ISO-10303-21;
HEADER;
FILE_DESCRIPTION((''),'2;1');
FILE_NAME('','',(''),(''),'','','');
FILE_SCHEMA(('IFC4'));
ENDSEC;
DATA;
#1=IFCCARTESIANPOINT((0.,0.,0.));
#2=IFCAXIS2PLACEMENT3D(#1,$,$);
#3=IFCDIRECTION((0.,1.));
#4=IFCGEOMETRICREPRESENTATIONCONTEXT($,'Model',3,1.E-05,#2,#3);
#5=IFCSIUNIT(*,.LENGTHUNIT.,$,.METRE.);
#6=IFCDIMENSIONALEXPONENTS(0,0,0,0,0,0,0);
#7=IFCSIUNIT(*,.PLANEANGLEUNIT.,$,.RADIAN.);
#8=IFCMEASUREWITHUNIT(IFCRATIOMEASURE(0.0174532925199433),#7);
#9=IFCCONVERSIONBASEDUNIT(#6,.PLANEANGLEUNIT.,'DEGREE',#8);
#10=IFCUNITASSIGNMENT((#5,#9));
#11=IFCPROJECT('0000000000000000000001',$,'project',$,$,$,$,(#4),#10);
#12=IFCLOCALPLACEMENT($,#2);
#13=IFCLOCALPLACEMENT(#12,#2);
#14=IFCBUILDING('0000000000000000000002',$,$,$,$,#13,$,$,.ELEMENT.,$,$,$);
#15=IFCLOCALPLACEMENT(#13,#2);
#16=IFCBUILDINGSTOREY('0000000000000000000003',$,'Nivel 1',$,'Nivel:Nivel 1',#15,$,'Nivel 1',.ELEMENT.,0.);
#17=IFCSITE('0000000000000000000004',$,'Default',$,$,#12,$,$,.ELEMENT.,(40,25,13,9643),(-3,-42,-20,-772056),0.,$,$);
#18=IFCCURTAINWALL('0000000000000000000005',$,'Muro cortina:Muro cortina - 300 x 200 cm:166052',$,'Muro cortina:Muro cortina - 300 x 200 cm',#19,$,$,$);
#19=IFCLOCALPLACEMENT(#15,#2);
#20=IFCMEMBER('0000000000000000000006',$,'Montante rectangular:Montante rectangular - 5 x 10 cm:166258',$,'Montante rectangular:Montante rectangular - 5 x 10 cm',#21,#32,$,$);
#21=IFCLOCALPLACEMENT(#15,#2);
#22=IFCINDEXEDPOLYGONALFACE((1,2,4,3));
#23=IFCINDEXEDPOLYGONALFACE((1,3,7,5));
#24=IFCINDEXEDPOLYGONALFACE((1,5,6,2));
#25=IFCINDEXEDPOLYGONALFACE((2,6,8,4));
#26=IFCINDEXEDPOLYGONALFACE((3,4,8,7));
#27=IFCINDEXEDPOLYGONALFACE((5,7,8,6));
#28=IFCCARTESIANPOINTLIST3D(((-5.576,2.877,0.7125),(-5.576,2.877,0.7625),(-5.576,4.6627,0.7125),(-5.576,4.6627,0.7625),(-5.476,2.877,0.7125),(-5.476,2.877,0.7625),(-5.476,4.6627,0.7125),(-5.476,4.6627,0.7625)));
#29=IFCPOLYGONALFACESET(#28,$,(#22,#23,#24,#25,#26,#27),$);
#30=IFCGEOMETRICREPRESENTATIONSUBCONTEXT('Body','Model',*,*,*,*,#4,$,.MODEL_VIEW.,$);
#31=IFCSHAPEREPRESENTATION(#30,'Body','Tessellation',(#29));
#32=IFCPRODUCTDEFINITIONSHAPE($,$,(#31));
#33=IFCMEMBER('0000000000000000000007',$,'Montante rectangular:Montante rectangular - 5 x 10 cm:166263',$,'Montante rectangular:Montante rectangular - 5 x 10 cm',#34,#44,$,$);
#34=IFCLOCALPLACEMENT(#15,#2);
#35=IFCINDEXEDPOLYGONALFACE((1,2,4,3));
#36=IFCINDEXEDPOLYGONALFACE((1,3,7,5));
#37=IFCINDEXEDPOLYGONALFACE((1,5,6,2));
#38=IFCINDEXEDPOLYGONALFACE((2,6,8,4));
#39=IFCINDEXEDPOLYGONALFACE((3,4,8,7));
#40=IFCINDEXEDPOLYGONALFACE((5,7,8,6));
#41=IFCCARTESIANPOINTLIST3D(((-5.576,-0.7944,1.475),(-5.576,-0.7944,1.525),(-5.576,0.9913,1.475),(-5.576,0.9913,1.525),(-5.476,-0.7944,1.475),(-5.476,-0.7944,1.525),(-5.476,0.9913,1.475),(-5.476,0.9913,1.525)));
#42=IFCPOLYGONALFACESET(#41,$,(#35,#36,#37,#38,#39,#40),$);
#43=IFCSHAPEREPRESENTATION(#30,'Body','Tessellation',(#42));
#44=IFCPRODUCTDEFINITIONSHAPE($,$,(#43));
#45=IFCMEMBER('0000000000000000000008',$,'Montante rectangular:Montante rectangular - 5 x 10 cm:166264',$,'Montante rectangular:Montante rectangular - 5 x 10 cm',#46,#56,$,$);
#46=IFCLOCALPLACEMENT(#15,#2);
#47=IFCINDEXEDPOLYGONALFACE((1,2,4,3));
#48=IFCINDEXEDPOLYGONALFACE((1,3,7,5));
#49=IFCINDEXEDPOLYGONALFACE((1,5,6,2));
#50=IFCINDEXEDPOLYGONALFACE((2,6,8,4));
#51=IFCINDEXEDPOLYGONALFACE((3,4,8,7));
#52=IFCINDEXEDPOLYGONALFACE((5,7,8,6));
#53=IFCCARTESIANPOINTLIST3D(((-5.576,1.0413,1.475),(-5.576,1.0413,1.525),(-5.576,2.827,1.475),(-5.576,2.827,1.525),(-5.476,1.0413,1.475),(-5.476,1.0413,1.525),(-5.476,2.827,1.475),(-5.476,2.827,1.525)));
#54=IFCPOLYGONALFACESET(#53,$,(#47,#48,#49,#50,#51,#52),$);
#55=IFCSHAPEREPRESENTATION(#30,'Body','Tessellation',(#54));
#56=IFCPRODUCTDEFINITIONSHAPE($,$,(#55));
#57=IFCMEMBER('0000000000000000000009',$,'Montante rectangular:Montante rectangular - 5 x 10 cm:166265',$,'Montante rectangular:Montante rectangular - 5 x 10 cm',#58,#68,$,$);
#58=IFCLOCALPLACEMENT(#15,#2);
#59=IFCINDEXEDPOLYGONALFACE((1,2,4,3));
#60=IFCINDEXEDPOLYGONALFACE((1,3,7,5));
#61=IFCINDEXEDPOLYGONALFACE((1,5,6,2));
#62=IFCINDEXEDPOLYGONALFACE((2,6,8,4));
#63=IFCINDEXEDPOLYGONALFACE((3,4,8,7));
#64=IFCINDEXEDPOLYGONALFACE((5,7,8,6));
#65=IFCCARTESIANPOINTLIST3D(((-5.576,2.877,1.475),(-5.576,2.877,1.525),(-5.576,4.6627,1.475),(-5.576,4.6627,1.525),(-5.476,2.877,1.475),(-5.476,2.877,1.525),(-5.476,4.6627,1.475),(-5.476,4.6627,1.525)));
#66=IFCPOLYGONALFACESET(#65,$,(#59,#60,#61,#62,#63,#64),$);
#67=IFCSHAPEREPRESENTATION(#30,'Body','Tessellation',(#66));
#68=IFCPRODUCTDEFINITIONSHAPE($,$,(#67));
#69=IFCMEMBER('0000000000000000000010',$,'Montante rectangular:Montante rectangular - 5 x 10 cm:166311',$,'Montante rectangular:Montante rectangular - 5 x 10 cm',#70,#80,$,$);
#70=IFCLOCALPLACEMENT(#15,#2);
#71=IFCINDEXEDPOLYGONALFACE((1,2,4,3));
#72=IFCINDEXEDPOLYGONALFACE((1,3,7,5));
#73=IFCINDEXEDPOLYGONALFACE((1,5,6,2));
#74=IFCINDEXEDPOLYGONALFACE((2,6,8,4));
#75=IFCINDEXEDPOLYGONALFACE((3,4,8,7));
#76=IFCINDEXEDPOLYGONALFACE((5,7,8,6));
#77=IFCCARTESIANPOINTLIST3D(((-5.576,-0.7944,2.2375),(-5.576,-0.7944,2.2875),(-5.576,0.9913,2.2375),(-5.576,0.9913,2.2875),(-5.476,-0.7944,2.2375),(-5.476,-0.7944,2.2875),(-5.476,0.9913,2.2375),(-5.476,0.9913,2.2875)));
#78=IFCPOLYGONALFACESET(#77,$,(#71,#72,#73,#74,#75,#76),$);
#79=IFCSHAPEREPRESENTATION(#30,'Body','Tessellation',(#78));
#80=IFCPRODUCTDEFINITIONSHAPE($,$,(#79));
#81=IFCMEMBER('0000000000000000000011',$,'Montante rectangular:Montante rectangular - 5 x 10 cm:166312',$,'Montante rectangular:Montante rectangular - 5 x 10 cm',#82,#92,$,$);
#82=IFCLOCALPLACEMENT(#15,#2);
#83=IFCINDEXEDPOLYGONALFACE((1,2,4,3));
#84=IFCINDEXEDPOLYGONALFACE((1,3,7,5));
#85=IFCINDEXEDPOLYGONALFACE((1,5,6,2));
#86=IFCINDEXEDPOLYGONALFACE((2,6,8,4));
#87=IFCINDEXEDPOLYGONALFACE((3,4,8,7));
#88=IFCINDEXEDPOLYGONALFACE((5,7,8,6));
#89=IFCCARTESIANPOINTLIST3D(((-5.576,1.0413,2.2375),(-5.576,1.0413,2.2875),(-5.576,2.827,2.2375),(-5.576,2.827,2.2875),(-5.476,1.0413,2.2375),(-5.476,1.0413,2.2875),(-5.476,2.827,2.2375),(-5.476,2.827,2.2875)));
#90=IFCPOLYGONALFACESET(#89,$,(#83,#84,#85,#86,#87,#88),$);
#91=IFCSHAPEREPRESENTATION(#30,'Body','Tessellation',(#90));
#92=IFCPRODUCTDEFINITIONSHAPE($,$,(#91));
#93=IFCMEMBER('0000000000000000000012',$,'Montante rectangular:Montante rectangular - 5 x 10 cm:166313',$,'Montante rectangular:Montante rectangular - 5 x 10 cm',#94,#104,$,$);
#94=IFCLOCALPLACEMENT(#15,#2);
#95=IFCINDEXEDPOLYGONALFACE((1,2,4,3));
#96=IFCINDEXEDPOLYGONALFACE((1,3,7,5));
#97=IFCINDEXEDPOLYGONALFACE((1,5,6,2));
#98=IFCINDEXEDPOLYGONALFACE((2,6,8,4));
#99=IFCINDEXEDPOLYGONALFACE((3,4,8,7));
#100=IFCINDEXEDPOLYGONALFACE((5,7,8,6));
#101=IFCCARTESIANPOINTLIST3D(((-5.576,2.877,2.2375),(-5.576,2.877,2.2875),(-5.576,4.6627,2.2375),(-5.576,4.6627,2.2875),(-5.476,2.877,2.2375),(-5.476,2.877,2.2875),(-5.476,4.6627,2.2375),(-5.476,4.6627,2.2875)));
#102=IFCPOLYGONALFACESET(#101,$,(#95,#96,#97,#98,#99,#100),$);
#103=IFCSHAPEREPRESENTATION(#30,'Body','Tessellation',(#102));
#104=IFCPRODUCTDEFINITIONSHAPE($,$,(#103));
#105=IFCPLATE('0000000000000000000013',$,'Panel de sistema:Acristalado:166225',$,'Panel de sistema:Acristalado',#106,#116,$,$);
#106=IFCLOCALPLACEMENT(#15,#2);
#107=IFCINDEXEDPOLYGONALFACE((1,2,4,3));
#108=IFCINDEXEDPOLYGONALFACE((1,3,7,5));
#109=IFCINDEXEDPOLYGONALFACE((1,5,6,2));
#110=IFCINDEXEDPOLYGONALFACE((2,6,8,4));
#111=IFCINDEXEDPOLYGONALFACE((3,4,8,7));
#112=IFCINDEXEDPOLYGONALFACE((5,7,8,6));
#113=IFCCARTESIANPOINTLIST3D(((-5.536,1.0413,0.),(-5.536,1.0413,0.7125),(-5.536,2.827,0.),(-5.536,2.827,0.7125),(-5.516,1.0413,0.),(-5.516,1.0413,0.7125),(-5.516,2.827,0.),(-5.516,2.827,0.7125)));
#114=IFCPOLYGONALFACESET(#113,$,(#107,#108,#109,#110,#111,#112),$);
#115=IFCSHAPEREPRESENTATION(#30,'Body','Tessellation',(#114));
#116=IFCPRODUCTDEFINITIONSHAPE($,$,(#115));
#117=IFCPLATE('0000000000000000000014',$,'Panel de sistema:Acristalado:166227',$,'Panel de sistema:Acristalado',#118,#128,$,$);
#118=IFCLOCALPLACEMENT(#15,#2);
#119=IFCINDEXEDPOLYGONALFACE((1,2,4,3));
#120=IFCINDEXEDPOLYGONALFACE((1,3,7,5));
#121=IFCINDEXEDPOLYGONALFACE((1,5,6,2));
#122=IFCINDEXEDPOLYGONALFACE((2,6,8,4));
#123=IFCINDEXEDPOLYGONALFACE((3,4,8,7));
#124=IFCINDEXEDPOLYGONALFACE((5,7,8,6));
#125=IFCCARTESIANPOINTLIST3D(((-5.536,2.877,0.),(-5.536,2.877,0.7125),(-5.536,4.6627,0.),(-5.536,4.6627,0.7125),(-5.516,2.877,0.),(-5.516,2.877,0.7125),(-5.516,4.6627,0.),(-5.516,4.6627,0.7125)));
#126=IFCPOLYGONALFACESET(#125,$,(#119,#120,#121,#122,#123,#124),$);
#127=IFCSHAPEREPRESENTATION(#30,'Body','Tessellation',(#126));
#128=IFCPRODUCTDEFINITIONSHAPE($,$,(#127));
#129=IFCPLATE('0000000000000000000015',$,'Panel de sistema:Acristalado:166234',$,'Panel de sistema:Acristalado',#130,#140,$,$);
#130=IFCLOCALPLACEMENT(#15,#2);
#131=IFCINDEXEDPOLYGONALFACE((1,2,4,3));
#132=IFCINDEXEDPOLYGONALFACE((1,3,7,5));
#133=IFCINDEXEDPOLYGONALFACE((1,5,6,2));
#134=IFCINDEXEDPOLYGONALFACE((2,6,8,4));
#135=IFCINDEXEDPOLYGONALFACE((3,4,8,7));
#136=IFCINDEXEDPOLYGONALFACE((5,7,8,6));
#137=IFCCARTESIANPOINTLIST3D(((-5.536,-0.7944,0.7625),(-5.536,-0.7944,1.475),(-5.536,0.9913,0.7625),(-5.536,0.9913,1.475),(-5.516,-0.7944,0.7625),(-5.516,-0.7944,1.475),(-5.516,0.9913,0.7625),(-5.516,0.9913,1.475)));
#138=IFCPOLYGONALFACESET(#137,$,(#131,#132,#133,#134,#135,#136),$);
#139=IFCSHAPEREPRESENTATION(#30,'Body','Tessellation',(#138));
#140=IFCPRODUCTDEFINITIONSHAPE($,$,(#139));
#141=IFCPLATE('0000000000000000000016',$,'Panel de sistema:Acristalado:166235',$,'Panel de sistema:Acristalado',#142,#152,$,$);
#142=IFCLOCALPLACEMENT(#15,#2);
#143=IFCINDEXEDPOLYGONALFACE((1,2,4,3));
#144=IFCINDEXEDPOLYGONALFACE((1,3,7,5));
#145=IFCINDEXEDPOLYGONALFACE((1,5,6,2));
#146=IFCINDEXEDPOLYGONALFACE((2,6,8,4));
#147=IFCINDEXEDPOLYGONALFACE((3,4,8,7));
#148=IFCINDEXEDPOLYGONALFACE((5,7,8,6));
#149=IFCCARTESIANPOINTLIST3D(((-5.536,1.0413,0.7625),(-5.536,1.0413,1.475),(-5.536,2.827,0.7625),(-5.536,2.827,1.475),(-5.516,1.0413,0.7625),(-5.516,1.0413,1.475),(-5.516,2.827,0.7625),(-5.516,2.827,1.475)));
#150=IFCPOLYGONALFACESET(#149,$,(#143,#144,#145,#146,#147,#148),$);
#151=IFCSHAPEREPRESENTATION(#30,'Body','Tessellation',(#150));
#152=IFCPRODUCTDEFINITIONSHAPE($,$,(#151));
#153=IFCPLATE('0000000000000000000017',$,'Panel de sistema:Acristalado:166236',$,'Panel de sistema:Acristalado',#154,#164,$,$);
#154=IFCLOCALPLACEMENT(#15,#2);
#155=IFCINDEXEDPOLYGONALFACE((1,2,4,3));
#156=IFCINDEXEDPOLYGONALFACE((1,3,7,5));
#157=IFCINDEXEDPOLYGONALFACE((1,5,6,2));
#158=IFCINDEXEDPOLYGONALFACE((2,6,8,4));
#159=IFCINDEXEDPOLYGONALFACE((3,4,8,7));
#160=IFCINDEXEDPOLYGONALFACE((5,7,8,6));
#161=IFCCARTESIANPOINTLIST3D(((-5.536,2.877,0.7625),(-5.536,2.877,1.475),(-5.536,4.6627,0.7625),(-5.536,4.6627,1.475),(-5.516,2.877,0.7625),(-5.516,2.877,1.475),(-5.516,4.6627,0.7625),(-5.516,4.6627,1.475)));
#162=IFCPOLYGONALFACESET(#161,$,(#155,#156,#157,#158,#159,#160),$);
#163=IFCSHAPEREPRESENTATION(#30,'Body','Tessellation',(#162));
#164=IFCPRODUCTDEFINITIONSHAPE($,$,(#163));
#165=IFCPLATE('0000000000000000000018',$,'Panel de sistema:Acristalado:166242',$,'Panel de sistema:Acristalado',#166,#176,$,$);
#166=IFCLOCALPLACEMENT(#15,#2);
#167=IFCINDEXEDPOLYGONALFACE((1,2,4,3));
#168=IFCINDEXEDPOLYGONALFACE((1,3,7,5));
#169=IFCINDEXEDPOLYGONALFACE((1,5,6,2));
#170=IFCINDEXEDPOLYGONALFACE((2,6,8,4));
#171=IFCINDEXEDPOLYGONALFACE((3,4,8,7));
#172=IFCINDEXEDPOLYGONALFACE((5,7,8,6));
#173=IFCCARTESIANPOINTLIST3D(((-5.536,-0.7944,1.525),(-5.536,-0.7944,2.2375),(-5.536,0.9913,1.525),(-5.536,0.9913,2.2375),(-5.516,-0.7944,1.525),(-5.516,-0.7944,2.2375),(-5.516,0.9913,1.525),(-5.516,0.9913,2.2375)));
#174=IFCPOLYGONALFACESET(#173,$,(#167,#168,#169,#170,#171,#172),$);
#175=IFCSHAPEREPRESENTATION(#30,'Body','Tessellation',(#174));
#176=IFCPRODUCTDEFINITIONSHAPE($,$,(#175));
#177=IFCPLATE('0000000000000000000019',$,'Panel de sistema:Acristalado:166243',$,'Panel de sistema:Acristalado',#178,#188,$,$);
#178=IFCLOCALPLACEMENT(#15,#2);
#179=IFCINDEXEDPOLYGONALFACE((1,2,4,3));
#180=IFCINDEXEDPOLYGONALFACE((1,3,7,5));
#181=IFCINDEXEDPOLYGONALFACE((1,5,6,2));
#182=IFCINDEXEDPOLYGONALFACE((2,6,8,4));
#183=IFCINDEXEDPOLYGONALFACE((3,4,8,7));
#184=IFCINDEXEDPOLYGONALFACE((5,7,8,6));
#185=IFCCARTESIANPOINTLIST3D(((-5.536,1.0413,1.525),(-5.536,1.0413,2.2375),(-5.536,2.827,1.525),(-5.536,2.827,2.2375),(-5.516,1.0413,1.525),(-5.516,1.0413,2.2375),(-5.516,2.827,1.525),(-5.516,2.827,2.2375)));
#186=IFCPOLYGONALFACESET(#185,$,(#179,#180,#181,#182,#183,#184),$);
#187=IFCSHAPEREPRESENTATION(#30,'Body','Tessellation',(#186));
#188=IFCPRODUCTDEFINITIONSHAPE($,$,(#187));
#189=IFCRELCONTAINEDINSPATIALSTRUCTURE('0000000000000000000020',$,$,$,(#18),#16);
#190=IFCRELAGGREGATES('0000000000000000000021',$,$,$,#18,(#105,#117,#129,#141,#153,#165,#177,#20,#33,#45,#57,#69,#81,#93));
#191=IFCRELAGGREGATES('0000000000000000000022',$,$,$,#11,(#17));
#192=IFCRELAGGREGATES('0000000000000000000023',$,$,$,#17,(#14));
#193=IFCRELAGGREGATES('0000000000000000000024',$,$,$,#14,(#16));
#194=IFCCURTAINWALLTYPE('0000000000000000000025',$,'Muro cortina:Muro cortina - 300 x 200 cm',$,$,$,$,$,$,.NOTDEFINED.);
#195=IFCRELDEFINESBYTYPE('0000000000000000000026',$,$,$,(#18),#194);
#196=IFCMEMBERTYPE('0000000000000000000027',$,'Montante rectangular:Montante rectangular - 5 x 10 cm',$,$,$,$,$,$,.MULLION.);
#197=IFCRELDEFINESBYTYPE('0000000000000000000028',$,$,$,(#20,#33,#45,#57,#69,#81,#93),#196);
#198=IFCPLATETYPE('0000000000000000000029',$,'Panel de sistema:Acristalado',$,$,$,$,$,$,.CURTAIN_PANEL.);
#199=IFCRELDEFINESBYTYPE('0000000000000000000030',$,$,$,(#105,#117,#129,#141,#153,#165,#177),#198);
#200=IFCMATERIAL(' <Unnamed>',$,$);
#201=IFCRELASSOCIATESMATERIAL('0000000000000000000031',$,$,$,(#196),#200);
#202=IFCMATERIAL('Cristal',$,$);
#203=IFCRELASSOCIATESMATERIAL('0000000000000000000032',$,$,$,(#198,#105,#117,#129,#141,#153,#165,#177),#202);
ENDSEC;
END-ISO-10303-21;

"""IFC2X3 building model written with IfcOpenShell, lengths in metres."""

from ifc_helpers import new_model, entity, si_unit, converted_unit, direction, frame, origin, origin_2d_with_axis, place, context, subcontext, project, spatial, rectangle, extrude, source, transform, mapped, material, type_object, type_shapes, element, aggregate, save


model = new_model("IFC2X3")

# Units and contexts
model_context = context("Model", 3, precision=1e-05, world=origin(), true_north=direction((0.0, 1.0)))
body_context = subcontext(model_context, "Body", "Model", "MODEL_VIEW")
ifc_project = project(units=[si_unit("LENGTHUNIT", "METRE"), converted_unit("PLANEANGLEUNIT", "DEGREE", entity("IfcRatioMeasure", 0.0174532925199433), si_unit("PLANEANGLEUNIT", "RADIAN"), dimensions=[0, 0, 0, 0, 0, 0, 0])], contexts=[model_context])

# Site, building, storey
site_placement = place(None, origin())
site = spatial("IfcSite", under=ifc_project, at=site_placement, Name="Default", CompositionType="ELEMENT", RefLatitude=(40, 25, 13, 9643), RefLongitude=(-3, -42, -20, -772056), RefElevation=0.0)
building_placement = place(site_placement, origin())
building = spatial("IfcBuilding", under=site, at=building_placement, CompositionType="ELEMENT")
storey_placement = place(building_placement, origin())
storey = spatial("IfcBuildingStorey", under=building, at=storey_placement, Name="Nivel 1", ObjectType="Nivel:Nivel 1", LongName="Nivel 1", CompositionType="ELEMENT", Elevation=0.0)

# Curtain wall, members, plates
curtain_wall_type = type_object("IfcCurtainWallType", Name="Muro cortina:Muro cortina - 300 x 200 cm", PredefinedType="NOTDEFINED")
curtain_wall_placement = place(storey_placement, origin())
curtain_wall = element("IfcCurtainWall", 1, at=curtain_wall_placement, inside=storey, type_object=curtain_wall_type, Name="Muro cortina:Muro cortina - 300 x 200 cm:166052", ObjectType="Muro cortina:Muro cortina - 300 x 200 cm")
ifc_material_1 = material(Name=" <Unnamed>")
member_type_1 = type_object("IfcMemberType", Name="Montante rectangular:Montante rectangular - 5 x 10 cm", PredefinedType="MULLION", material=ifc_material_1)
shared_shape_1 = source(origin(), body_context, "Body", "SweptSolid", [
    extrude(rectangle(XDim=0.1, YDim=0.05, at=origin_2d_with_axis()), frame((0.0, 0.0, -1.7857), z_axis=(0.0, 0.0, 1.0), x_axis=(0.0, -1.0, 0.0)), (0.0, 0.0, 1.0), 1.7857),
])
type_shapes(member_type_1, [shared_shape_1])
member_1_placement = place(storey_placement, frame((-5.526, 4.6627, 0.7375), z_axis=(0.0, 1.0, 0.0), x_axis=(0.0, 0.0, 1.0)))
member_1 = element("IfcMember", 2, at=member_1_placement, type_object=member_type_1, Name="Montante rectangular:Montante rectangular - 5 x 10 cm:166258", ObjectType="Montante rectangular:Montante rectangular - 5 x 10 cm", context=body_context, shape_type="MappedRepresentation", body=[
    mapped(shared_shape_1, transform((0.0, 0.0, 0.0), scale=1.0)),
])
member_2_placement = place(storey_placement, frame((-5.526, 0.9913, 1.5), z_axis=(0.0, 1.0, 0.0), x_axis=(0.0, 0.0, 1.0)))
member_2 = element("IfcMember", 3, at=member_2_placement, type_object=member_type_1, Name="Montante rectangular:Montante rectangular - 5 x 10 cm:166263", ObjectType="Montante rectangular:Montante rectangular - 5 x 10 cm", context=body_context, shape_type="MappedRepresentation", body=[
    mapped(shared_shape_1, transform((0.0, 0.0, 0.0), scale=1.0)),
])
member_3_placement = place(storey_placement, frame((-5.526, 2.827, 1.5), z_axis=(0.0, 1.0, 0.0), x_axis=(0.0, 0.0, 1.0)))
member_3 = element("IfcMember", 4, at=member_3_placement, type_object=member_type_1, Name="Montante rectangular:Montante rectangular - 5 x 10 cm:166264", ObjectType="Montante rectangular:Montante rectangular - 5 x 10 cm", context=body_context, shape_type="MappedRepresentation", body=[
    mapped(shared_shape_1, transform((0.0, 0.0, 0.0), scale=1.0)),
])
member_4_placement = place(storey_placement, frame((-5.526, 4.6627, 1.5), z_axis=(0.0, 1.0, 0.0), x_axis=(0.0, 0.0, 1.0)))
member_4 = element("IfcMember", 5, at=member_4_placement, type_object=member_type_1, Name="Montante rectangular:Montante rectangular - 5 x 10 cm:166265", ObjectType="Montante rectangular:Montante rectangular - 5 x 10 cm", context=body_context, shape_type="MappedRepresentation", body=[
    mapped(shared_shape_1, transform((0.0, 0.0, 0.0), scale=1.0)),
])
member_5_placement = place(storey_placement, frame((-5.526, 0.9913, 2.2625), z_axis=(0.0, 1.0, 0.0), x_axis=(0.0, 0.0, 1.0)))
member_5 = element("IfcMember", 6, at=member_5_placement, type_object=member_type_1, Name="Montante rectangular:Montante rectangular - 5 x 10 cm:166311", ObjectType="Montante rectangular:Montante rectangular - 5 x 10 cm", context=body_context, shape_type="MappedRepresentation", body=[
    mapped(shared_shape_1, transform((0.0, 0.0, 0.0), scale=1.0)),
])
member_6_placement = place(storey_placement, frame((-5.526, 2.827, 2.2625), z_axis=(0.0, 1.0, 0.0), x_axis=(0.0, 0.0, 1.0)))
member_6 = element("IfcMember", 7, at=member_6_placement, type_object=member_type_1, Name="Montante rectangular:Montante rectangular - 5 x 10 cm:166312", ObjectType="Montante rectangular:Montante rectangular - 5 x 10 cm", context=body_context, shape_type="MappedRepresentation", body=[
    mapped(shared_shape_1, transform((0.0, 0.0, 0.0), scale=1.0)),
])
member_7_placement = place(storey_placement, frame((-5.526, 4.6627, 2.2625), z_axis=(0.0, 1.0, 0.0), x_axis=(0.0, 0.0, 1.0)))
member_7 = element("IfcMember", 8, at=member_7_placement, type_object=member_type_1, Name="Montante rectangular:Montante rectangular - 5 x 10 cm:166313", ObjectType="Montante rectangular:Montante rectangular - 5 x 10 cm", context=body_context, shape_type="MappedRepresentation", body=[
    mapped(shared_shape_1, transform((0.0, 0.0, 0.0), scale=1.0)),
])
ifc_material_2 = material(Name="Cristal")
plate_type = type_object("IfcPlateType", Name="Panel de sistema:Acristalado", PredefinedType="CURTAIN_PANEL", material=ifc_material_2)
shared_shape_2 = source(origin(), body_context, "Body", "SweptSolid", [
    extrude(rectangle(XDim=0.02, YDim=1.7857, at=origin_2d_with_axis()), frame((0.0, 0.0, 0.0), z_axis=(0.0, 0.0, 1.0), x_axis=(0.0, 1.0, 0.0)), (0.0, 0.0, 1.0), 0.7125),
])
type_shapes(plate_type, [shared_shape_2])
plate_1_placement = place(curtain_wall_placement, frame((-5.526, 1.9342, 0.0), z_axis=(0.0, 0.0, 1.0), x_axis=(0.0, 1.0, 0.0)))
plate_1 = element("IfcPlate", 9, at=plate_1_placement, type_object=plate_type, material=ifc_material_2, Name="Panel de sistema:Acristalado:166225", ObjectType="Panel de sistema:Acristalado", context=body_context, shape_type="MappedRepresentation", body=[
    mapped(shared_shape_2, transform((0.0, 0.0, 0.0), scale=1.0)),
])
plate_2_placement = place(curtain_wall_placement, frame((-5.526, 3.7699, 0.0), z_axis=(0.0, 0.0, 1.0), x_axis=(0.0, 1.0, 0.0)))
plate_2 = element("IfcPlate", 10, at=plate_2_placement, type_object=plate_type, material=ifc_material_2, Name="Panel de sistema:Acristalado:166227", ObjectType="Panel de sistema:Acristalado", context=body_context, shape_type="MappedRepresentation", body=[
    mapped(shared_shape_2, transform((0.0, 0.0, 0.0), scale=1.0)),
])
plate_3_placement = place(curtain_wall_placement, frame((-5.526, 0.0985, 0.7625), z_axis=(0.0, 0.0, 1.0), x_axis=(0.0, 1.0, 0.0)))
plate_3 = element("IfcPlate", 11, at=plate_3_placement, type_object=plate_type, material=ifc_material_2, Name="Panel de sistema:Acristalado:166234", ObjectType="Panel de sistema:Acristalado", context=body_context, shape_type="MappedRepresentation", body=[
    mapped(shared_shape_2, transform((0.0, 0.0, 0.0), scale=1.0)),
])
plate_4_placement = place(curtain_wall_placement, frame((-5.526, 1.9342, 0.7625), z_axis=(0.0, 0.0, 1.0), x_axis=(0.0, 1.0, 0.0)))
plate_4 = element("IfcPlate", 12, at=plate_4_placement, type_object=plate_type, material=ifc_material_2, Name="Panel de sistema:Acristalado:166235", ObjectType="Panel de sistema:Acristalado", context=body_context, shape_type="MappedRepresentation", body=[
    mapped(shared_shape_2, transform((0.0, 0.0, 0.0), scale=1.0)),
])
plate_5_placement = place(curtain_wall_placement, frame((-5.526, 3.7699, 0.7625), z_axis=(0.0, 0.0, 1.0), x_axis=(0.0, 1.0, 0.0)))
plate_5 = element("IfcPlate", 13, at=plate_5_placement, type_object=plate_type, material=ifc_material_2, Name="Panel de sistema:Acristalado:166236", ObjectType="Panel de sistema:Acristalado", context=body_context, shape_type="MappedRepresentation", body=[
    mapped(shared_shape_2, transform((0.0, 0.0, 0.0), scale=1.0)),
])
plate_6_placement = place(curtain_wall_placement, frame((-5.526, 0.0985, 1.525), z_axis=(0.0, 0.0, 1.0), x_axis=(0.0, 1.0, 0.0)))
plate_6 = element("IfcPlate", 14, at=plate_6_placement, type_object=plate_type, material=ifc_material_2, Name="Panel de sistema:Acristalado:166242", ObjectType="Panel de sistema:Acristalado", context=body_context, shape_type="MappedRepresentation", body=[
    mapped(shared_shape_2, transform((0.0, 0.0, 0.0), scale=1.0)),
])
plate_7_placement = place(curtain_wall_placement, frame((-5.526, 1.9342, 1.525), z_axis=(0.0, 0.0, 1.0), x_axis=(0.0, 1.0, 0.0)))
plate_7 = element("IfcPlate", 15, at=plate_7_placement, type_object=plate_type, material=ifc_material_2, Name="Panel de sistema:Acristalado:166243", ObjectType="Panel de sistema:Acristalado", context=body_context, shape_type="MappedRepresentation", body=[
    mapped(shared_shape_2, transform((0.0, 0.0, 0.0), scale=1.0)),
])
aggregate(curtain_wall, [plate_1, plate_2, plate_3, plate_4, plate_5, plate_6, plate_7, member_1, member_2, member_3, member_4, member_5, member_6, member_7])

save(model, "model.ifc")
